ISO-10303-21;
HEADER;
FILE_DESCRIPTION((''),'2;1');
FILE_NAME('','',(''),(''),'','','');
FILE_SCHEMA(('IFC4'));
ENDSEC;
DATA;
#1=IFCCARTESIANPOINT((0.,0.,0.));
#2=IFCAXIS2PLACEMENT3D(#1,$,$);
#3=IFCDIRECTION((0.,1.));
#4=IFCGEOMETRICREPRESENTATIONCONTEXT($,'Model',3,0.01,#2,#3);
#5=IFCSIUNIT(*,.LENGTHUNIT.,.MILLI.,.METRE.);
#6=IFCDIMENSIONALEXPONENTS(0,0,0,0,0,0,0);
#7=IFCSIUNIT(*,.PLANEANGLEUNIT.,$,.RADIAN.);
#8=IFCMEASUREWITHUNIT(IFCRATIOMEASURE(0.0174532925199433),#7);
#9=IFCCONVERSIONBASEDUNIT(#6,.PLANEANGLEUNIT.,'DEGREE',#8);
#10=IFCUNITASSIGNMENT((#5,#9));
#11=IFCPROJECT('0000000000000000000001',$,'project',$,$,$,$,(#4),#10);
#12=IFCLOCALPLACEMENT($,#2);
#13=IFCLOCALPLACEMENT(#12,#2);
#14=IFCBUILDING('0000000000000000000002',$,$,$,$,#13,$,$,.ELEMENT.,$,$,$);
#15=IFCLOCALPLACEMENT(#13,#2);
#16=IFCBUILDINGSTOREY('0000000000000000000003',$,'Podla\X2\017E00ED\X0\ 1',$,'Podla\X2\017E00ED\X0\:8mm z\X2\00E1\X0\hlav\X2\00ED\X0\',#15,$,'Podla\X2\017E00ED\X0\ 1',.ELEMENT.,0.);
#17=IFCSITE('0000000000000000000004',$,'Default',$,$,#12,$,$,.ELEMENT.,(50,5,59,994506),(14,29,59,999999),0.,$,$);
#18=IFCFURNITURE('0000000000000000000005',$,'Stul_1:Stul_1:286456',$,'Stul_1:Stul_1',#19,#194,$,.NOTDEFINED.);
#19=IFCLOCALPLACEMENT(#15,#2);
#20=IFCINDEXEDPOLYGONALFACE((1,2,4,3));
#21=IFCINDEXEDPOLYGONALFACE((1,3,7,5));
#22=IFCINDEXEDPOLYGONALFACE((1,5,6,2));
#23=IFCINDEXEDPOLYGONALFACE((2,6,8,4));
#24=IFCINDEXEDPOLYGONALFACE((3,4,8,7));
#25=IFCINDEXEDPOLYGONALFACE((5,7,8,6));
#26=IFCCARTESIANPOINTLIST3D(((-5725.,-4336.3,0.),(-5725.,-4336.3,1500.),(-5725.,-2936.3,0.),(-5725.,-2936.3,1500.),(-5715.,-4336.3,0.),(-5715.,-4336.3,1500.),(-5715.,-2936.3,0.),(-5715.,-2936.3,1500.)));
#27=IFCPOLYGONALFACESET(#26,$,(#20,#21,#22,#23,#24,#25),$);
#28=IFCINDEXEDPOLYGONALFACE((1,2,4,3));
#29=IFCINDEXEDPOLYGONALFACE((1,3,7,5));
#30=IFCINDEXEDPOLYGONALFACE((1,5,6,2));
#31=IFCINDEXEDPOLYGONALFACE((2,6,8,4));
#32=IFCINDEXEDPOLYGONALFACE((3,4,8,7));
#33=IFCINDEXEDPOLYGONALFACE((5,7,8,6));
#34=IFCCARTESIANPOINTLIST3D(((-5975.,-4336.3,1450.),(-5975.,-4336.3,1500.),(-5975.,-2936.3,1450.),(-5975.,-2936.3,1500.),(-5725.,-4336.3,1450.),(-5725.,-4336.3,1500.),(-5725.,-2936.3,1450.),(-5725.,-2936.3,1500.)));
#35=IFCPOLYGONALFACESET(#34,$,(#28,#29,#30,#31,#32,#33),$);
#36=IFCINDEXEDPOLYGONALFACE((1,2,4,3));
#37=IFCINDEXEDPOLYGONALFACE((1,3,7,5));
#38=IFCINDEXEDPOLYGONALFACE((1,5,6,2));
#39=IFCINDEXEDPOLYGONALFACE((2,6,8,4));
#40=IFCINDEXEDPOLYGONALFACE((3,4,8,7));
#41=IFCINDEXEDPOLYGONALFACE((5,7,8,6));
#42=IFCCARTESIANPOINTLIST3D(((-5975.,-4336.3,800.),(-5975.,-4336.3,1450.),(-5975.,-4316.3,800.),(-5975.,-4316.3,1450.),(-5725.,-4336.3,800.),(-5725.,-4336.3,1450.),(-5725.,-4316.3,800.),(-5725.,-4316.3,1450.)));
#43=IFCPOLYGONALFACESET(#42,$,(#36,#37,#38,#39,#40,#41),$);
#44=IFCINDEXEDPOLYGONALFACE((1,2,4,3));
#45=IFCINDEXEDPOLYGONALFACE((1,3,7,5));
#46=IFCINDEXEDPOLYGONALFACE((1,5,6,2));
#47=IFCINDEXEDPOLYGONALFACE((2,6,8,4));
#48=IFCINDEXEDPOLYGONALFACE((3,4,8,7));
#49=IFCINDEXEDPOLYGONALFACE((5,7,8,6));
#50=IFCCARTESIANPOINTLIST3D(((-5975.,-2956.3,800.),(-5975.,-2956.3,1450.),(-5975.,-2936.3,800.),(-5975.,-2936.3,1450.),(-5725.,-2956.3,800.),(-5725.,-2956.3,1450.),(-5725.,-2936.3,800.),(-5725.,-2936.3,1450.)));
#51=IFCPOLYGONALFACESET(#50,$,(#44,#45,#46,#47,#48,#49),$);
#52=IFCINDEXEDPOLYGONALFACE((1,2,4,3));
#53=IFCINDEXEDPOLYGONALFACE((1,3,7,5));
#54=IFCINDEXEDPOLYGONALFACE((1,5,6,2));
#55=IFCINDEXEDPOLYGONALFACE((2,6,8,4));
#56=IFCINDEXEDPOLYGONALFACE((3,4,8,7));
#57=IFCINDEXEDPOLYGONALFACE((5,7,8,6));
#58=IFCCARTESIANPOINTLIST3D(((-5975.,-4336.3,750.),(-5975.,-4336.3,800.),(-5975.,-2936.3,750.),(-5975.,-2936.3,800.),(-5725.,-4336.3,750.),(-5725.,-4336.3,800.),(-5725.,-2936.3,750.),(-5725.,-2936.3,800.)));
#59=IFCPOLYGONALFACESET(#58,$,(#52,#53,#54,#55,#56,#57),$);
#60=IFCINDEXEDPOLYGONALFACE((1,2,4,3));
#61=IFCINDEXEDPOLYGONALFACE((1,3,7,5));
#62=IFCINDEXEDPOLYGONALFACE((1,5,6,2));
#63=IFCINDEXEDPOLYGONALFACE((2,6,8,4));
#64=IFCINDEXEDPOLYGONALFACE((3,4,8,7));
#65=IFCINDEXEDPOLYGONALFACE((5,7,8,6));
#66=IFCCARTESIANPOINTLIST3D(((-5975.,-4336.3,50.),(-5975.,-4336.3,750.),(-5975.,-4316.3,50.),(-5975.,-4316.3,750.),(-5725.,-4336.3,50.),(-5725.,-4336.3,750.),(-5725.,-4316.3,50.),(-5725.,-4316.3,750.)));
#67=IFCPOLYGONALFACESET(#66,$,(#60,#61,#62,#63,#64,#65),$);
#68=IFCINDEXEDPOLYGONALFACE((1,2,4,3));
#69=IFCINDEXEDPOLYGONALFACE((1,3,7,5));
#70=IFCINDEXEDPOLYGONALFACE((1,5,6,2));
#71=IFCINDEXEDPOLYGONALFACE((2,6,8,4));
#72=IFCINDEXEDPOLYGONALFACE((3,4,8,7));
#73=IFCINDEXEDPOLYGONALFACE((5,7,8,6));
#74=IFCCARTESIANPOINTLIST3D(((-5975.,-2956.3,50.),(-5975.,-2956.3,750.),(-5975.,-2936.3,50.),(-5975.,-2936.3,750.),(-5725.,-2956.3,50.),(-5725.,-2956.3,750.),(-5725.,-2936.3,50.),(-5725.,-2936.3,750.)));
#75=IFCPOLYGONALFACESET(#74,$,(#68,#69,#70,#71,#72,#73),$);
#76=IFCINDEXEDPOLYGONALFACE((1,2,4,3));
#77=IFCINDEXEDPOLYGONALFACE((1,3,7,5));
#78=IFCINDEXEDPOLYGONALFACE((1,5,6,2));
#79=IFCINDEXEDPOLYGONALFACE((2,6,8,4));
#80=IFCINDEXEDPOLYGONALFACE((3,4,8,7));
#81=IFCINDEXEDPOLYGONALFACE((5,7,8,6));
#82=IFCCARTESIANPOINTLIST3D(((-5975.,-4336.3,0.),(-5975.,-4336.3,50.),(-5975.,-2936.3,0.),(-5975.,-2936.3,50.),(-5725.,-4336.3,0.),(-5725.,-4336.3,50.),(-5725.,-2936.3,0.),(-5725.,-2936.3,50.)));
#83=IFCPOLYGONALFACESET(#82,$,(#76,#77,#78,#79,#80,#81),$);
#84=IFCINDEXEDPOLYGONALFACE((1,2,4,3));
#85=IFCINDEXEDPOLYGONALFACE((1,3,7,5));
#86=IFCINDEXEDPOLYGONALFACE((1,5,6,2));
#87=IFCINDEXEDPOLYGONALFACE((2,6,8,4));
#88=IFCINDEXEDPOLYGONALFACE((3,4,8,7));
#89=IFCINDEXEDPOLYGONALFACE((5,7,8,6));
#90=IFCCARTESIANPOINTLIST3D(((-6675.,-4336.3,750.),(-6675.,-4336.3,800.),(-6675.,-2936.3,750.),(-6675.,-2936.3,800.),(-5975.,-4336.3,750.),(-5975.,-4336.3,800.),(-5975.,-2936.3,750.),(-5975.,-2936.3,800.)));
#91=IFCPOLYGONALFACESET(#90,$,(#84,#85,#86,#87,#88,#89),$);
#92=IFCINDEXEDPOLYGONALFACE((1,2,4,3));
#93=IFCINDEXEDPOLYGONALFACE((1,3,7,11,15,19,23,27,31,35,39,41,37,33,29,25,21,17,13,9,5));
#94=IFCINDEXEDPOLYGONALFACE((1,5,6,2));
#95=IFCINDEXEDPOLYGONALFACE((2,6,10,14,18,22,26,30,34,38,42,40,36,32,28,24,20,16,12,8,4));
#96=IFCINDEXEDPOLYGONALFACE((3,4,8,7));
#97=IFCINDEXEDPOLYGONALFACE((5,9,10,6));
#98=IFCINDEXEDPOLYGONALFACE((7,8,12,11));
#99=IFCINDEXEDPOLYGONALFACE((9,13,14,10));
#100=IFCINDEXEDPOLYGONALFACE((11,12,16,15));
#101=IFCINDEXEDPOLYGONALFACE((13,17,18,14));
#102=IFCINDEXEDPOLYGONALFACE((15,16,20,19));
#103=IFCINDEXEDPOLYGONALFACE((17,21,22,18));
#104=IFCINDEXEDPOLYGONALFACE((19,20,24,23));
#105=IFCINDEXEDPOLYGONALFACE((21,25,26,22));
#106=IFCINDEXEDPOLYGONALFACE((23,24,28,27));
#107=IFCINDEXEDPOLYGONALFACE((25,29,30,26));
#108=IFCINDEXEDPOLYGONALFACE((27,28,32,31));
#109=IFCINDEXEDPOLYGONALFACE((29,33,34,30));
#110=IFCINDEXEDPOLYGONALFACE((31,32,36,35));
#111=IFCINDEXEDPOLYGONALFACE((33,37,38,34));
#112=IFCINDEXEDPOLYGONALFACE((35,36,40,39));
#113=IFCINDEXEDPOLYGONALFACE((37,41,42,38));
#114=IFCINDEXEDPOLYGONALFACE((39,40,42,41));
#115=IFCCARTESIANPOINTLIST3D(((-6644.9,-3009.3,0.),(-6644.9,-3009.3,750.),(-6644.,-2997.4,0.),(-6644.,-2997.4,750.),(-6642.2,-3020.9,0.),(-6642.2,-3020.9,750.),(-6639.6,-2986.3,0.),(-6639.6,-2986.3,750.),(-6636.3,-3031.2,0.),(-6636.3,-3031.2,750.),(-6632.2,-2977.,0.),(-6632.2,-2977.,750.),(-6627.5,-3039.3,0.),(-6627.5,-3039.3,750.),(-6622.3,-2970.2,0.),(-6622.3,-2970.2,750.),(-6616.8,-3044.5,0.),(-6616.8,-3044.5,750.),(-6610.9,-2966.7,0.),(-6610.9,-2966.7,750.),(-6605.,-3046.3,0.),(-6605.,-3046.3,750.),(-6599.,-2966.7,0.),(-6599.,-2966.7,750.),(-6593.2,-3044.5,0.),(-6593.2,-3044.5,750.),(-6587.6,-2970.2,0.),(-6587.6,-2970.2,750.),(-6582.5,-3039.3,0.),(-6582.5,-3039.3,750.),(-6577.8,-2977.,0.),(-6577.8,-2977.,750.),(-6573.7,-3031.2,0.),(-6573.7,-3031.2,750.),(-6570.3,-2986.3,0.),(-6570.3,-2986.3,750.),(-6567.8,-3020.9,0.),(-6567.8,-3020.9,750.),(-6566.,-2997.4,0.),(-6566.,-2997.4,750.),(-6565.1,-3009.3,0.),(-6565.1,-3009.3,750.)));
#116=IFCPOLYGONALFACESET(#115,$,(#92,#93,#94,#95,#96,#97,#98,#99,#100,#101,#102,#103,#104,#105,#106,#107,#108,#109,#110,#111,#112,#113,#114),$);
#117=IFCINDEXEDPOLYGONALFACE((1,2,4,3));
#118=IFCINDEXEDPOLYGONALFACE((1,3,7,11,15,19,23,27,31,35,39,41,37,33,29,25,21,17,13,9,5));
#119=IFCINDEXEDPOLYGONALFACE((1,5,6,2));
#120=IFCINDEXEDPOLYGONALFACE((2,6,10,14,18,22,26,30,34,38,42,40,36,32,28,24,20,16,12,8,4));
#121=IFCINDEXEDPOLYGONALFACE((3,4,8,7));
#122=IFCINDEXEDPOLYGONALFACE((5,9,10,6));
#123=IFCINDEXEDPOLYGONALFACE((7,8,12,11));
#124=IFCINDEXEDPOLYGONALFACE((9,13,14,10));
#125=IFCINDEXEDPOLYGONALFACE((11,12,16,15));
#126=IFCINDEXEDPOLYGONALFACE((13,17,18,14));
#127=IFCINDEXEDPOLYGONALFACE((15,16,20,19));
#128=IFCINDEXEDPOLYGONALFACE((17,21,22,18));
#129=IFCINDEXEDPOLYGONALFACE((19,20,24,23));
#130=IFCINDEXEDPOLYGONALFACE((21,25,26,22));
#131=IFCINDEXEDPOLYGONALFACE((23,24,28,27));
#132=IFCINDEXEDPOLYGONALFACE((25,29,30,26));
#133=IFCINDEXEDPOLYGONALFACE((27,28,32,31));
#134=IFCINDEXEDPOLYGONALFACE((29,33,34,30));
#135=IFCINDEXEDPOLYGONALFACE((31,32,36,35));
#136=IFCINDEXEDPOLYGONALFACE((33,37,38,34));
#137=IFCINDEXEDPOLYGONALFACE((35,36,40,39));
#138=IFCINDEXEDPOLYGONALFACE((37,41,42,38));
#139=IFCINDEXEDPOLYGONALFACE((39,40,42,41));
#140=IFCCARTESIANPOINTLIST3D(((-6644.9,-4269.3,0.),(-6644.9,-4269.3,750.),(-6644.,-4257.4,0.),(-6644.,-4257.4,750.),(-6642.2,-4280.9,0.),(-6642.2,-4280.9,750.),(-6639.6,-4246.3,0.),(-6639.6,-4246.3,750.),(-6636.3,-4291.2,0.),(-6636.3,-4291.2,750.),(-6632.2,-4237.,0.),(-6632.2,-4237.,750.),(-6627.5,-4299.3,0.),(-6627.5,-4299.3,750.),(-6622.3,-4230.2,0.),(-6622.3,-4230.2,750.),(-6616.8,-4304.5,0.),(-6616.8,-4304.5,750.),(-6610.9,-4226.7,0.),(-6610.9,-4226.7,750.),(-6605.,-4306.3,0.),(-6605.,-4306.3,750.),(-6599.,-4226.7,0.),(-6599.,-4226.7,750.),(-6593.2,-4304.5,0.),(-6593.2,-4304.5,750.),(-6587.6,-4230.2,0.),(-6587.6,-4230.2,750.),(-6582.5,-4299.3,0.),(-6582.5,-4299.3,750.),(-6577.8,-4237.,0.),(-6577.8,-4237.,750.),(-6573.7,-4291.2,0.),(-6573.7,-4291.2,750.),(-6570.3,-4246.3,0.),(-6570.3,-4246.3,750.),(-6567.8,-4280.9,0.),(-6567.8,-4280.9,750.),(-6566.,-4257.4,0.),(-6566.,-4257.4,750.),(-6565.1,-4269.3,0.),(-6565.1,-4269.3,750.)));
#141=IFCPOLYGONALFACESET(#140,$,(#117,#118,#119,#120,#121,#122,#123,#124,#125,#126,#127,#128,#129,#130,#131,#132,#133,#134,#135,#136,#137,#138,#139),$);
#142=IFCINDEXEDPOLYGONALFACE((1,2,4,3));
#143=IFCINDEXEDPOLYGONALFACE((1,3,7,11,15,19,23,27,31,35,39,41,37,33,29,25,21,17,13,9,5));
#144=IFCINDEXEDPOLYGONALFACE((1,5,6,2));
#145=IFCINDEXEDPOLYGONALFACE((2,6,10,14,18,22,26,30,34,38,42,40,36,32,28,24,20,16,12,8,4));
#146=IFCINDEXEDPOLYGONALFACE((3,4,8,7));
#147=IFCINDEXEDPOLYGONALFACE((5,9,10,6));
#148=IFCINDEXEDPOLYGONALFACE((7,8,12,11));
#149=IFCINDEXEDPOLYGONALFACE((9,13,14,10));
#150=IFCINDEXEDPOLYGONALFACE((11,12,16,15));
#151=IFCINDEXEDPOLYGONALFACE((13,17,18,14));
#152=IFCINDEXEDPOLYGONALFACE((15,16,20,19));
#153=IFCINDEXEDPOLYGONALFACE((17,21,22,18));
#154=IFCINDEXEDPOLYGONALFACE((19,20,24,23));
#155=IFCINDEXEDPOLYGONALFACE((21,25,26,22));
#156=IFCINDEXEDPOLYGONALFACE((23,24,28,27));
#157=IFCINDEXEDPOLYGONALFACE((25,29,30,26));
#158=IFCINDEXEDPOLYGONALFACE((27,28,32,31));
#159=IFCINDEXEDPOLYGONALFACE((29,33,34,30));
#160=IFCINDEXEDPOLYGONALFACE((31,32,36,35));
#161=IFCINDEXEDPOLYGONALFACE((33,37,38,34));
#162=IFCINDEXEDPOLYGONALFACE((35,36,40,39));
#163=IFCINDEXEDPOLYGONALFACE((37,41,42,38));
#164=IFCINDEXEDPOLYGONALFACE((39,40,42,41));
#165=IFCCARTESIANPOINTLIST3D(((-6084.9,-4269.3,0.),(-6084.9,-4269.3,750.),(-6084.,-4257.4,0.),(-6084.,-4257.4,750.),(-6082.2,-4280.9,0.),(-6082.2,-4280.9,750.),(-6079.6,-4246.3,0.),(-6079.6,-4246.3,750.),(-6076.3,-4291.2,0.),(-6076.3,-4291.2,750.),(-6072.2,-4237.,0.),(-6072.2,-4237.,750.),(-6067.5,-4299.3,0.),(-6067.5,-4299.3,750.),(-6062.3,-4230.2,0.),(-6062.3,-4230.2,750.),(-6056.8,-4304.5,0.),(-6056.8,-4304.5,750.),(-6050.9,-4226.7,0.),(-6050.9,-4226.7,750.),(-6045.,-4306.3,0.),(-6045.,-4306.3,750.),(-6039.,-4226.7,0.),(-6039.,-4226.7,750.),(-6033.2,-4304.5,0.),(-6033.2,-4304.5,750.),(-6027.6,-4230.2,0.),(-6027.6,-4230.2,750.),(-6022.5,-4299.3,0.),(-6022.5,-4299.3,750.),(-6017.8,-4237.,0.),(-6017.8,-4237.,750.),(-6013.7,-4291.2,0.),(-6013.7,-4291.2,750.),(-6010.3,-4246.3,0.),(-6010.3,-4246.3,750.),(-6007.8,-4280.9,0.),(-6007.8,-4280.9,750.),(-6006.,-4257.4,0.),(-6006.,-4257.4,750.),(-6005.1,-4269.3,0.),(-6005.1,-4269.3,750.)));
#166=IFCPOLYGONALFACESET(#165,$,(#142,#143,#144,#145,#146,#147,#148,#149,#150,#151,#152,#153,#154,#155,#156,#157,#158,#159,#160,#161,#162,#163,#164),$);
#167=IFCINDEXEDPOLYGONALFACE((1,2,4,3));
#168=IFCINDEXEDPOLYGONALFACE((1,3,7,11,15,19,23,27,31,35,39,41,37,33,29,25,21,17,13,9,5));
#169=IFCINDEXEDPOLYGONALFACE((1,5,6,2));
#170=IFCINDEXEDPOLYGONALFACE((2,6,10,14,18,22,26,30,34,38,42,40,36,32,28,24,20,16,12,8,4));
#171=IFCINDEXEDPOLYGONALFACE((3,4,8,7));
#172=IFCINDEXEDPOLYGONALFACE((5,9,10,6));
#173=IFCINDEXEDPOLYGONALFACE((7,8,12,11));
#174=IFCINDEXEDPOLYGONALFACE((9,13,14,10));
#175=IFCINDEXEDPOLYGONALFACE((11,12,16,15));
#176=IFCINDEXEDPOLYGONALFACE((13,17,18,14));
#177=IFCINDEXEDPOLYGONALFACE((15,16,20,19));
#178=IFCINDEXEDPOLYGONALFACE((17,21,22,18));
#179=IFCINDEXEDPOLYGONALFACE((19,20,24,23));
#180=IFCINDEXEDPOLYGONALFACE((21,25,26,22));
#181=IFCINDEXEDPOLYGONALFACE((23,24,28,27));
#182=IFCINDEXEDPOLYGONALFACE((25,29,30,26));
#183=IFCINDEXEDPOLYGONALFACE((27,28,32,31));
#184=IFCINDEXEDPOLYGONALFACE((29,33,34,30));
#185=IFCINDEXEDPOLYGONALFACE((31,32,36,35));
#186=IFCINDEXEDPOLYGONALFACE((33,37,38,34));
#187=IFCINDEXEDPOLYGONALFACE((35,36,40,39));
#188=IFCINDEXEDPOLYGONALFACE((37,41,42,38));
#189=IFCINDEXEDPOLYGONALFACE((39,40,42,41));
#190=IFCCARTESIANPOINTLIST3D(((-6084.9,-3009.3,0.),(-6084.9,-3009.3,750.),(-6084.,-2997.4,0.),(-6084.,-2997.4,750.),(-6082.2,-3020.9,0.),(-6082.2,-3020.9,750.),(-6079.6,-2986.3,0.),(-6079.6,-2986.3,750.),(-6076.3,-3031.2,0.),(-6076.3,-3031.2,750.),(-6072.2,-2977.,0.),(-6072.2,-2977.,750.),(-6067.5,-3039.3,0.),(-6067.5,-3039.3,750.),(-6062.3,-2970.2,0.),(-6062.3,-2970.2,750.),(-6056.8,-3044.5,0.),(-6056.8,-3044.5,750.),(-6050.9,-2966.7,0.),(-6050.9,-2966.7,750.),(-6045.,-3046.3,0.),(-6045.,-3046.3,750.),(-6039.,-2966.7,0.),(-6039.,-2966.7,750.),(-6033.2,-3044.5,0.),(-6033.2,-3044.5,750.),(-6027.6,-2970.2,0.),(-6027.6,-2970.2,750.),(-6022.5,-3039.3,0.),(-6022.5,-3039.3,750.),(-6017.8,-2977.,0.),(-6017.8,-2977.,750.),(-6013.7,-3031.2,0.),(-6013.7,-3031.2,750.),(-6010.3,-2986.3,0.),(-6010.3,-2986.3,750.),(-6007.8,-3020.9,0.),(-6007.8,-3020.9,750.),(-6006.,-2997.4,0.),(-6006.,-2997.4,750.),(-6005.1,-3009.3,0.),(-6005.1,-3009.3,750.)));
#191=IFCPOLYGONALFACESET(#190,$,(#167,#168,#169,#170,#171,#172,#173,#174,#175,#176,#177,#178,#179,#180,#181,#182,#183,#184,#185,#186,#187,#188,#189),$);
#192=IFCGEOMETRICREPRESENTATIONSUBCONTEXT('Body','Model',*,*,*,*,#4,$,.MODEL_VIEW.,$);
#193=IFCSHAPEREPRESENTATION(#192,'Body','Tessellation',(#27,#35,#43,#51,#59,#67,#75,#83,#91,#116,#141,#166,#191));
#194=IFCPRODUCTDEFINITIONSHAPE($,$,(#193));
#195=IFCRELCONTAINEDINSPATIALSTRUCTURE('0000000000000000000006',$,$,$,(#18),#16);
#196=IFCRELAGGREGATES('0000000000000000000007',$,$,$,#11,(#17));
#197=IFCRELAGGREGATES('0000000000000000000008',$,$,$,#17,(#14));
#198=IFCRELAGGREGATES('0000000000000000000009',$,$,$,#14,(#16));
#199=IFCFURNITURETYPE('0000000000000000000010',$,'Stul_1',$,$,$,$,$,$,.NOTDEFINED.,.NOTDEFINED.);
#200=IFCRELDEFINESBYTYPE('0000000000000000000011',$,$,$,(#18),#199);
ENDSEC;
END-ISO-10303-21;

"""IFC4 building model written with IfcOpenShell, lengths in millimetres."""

from ifc_helpers import new_model, entity, si_unit, converted_unit, direction, frame, frame_2d, origin, origin_2d_with_axis, place, context, subcontext, project, spatial, rectangle, circle, extrude, source, transform, mapped, type_object, type_shapes, element, save


model = new_model("IFC4")

# Units and contexts
model_context = context("Model", 3, precision=0.01, world=origin(), true_north=direction((0.0, 1.0)))
body_context = subcontext(model_context, "Body", "Model", "MODEL_VIEW")
ifc_project = project(units=[si_unit("LENGTHUNIT", "METRE", prefix="MILLI"), converted_unit("PLANEANGLEUNIT", "DEGREE", entity("IfcRatioMeasure", 0.0174532925199433), si_unit("PLANEANGLEUNIT", "RADIAN"), dimensions=[0, 0, 0, 0, 0, 0, 0])], contexts=[model_context])

# Site, building, storey
site_placement = place(None, origin())
site = spatial("IfcSite", under=ifc_project, at=site_placement, Name="Default", CompositionType="ELEMENT", RefLatitude=(50, 5, 59, 994506), RefLongitude=(14, 29, 59, 999999), RefElevation=0.0)
building_placement = place(site_placement, origin())
building = spatial("IfcBuilding", under=site, at=building_placement, CompositionType="ELEMENT")
storey_placement = place(building_placement, origin())
storey = spatial("IfcBuildingStorey", under=building, at=storey_placement, Name="Podlaží 1", ObjectType="Podlaží:8mm záhlaví", LongName="Podlaží 1", CompositionType="ELEMENT", Elevation=0.0)

# Furniture
furniture_type = type_object("IfcFurnitureType", Name="Stul_1", AssemblyPlace="NOTDEFINED", PredefinedType="NOTDEFINED")
shared_shape_1 = source(origin(), body_context, "Body", "SweptSolid", [
    extrude(rectangle(XDim=1400.0, YDim=10.0, at=origin_2d_with_axis()), frame((0.0, 605.0, 0.0), z_axis=(0.0, 0.0, 1.0), x_axis=(-1.0, 0.0, 0.0)), (0.0, 0.0, 1.0), 1500.0),
    extrude(rectangle(XDim=1400.0, YDim=250.0, at=frame_2d((0.0, 0.0), x_axis=(1.0, 0.0))), frame((0.0, 475.0, 1450.0), z_axis=(0.0, 0.0, 1.0), x_axis=(-1.0, 0.0, 0.0)), (0.0, 0.0, 1.0), 50.0),
    extrude(rectangle(XDim=20.0, YDim=250.0, at=origin_2d_with_axis()), frame((690.0, 475.0, 800.0), z_axis=(0.0, 0.0, 1.0), x_axis=(-1.0, 0.0, 0.0)), (0.0, 0.0, 1.0), 650.0),
    extrude(rectangle(XDim=20.0, YDim=250.0, at=frame_2d((0.0, 0.0), x_axis=(1.0, 0.0))), frame((-690.0, 475.0, 800.0), z_axis=(0.0, 0.0, 1.0), x_axis=(-1.0, 0.0, 0.0)), (0.0, 0.0, 1.0), 650.0),
    extrude(rectangle(XDim=1400.0, YDim=250.0, at=origin_2d_with_axis()), frame((0.0, 475.0, 750.0), z_axis=(0.0, 0.0, 1.0), x_axis=(-1.0, 0.0, 0.0)), (0.0, 0.0, 1.0), 50.0),
    extrude(rectangle(XDim=20.0, YDim=250.0, at=origin_2d_with_axis()), frame((690.0, 475.0, 50.0), z_axis=(0.0, 0.0, 1.0), x_axis=(-1.0, 0.0, 0.0)), (0.0, 0.0, 1.0), 700.0),
    extrude(rectangle(XDim=20.0, YDim=250.0, at=frame_2d((0.0, 0.0), x_axis=(1.0, 0.0))), frame((-690.0, 475.0, 50.0), z_axis=(0.0, 0.0, 1.0), x_axis=(-1.0, 0.0, 0.0)), (0.0, 0.0, 1.0), 700.0),
    extrude(rectangle(XDim=1400.0, YDim=250.0, at=origin_2d_with_axis()), frame((0.0, 475.0, 0.0), z_axis=(0.0, 0.0, 1.0), x_axis=(-1.0, 0.0, 0.0)), (0.0, 0.0, 1.0), 50.0),
    extrude(rectangle(XDim=1400.0, YDim=700.0, at=origin_2d_with_axis()), frame((0.0, 0.0, 750.0), z_axis=(0.0, 0.0, 1.0), x_axis=(-1.0, 0.0, 0.0)), (0.0, 0.0, 1.0), 50.0),
    extrude(circle(Radius=40.0, at=frame_2d((0.0, 0.0), x_axis=(1.0, 0.0))), frame((-630.0, -280.0, 0.0)), (0.0, 0.0, 1.0), 750.0),
    extrude(circle(Radius=40.0, at=frame_2d((0.0, 0.0), x_axis=(1.0, 0.0))), frame((630.0, -280.0, 0.0)), (0.0, 0.0, 1.0), 750.0),
    extrude(circle(Radius=40.0, at=frame_2d((0.0, 0.0), x_axis=(1.0, 0.0))), frame((630.0, 280.0, 0.0)), (0.0, 0.0, 1.0), 750.0),
    extrude(circle(Radius=40.0, at=frame_2d((0.0, 0.0), x_axis=(1.0, 0.0))), frame((-630.0, 280.0, 0.0)), (0.0, 0.0, 1.0), 750.0),
])
type_shapes(furniture_type, [shared_shape_1])
for number, where, z_axis, x_axis, name in (
    (1, (-6325.0, -3636.3, 0.0), (0.0, 0.0, 1.0), (0.0, -1.0, 0.0), "Stul_1:Stul_1:286456"),
):
    element("IfcFurniture", number, at=place(storey_placement, frame(where, z_axis=z_axis, x_axis=x_axis)), inside=storey, type_object=furniture_type, Name=name, ObjectType="Stul_1:Stul_1", PredefinedType="NOTDEFINED", context=body_context, shape_type="MappedRepresentation", body=[
        mapped(shared_shape_1, transform((0.0, 0.0, 0.0), scale=1.0)),
    ])

save(model, "model.ifc")
